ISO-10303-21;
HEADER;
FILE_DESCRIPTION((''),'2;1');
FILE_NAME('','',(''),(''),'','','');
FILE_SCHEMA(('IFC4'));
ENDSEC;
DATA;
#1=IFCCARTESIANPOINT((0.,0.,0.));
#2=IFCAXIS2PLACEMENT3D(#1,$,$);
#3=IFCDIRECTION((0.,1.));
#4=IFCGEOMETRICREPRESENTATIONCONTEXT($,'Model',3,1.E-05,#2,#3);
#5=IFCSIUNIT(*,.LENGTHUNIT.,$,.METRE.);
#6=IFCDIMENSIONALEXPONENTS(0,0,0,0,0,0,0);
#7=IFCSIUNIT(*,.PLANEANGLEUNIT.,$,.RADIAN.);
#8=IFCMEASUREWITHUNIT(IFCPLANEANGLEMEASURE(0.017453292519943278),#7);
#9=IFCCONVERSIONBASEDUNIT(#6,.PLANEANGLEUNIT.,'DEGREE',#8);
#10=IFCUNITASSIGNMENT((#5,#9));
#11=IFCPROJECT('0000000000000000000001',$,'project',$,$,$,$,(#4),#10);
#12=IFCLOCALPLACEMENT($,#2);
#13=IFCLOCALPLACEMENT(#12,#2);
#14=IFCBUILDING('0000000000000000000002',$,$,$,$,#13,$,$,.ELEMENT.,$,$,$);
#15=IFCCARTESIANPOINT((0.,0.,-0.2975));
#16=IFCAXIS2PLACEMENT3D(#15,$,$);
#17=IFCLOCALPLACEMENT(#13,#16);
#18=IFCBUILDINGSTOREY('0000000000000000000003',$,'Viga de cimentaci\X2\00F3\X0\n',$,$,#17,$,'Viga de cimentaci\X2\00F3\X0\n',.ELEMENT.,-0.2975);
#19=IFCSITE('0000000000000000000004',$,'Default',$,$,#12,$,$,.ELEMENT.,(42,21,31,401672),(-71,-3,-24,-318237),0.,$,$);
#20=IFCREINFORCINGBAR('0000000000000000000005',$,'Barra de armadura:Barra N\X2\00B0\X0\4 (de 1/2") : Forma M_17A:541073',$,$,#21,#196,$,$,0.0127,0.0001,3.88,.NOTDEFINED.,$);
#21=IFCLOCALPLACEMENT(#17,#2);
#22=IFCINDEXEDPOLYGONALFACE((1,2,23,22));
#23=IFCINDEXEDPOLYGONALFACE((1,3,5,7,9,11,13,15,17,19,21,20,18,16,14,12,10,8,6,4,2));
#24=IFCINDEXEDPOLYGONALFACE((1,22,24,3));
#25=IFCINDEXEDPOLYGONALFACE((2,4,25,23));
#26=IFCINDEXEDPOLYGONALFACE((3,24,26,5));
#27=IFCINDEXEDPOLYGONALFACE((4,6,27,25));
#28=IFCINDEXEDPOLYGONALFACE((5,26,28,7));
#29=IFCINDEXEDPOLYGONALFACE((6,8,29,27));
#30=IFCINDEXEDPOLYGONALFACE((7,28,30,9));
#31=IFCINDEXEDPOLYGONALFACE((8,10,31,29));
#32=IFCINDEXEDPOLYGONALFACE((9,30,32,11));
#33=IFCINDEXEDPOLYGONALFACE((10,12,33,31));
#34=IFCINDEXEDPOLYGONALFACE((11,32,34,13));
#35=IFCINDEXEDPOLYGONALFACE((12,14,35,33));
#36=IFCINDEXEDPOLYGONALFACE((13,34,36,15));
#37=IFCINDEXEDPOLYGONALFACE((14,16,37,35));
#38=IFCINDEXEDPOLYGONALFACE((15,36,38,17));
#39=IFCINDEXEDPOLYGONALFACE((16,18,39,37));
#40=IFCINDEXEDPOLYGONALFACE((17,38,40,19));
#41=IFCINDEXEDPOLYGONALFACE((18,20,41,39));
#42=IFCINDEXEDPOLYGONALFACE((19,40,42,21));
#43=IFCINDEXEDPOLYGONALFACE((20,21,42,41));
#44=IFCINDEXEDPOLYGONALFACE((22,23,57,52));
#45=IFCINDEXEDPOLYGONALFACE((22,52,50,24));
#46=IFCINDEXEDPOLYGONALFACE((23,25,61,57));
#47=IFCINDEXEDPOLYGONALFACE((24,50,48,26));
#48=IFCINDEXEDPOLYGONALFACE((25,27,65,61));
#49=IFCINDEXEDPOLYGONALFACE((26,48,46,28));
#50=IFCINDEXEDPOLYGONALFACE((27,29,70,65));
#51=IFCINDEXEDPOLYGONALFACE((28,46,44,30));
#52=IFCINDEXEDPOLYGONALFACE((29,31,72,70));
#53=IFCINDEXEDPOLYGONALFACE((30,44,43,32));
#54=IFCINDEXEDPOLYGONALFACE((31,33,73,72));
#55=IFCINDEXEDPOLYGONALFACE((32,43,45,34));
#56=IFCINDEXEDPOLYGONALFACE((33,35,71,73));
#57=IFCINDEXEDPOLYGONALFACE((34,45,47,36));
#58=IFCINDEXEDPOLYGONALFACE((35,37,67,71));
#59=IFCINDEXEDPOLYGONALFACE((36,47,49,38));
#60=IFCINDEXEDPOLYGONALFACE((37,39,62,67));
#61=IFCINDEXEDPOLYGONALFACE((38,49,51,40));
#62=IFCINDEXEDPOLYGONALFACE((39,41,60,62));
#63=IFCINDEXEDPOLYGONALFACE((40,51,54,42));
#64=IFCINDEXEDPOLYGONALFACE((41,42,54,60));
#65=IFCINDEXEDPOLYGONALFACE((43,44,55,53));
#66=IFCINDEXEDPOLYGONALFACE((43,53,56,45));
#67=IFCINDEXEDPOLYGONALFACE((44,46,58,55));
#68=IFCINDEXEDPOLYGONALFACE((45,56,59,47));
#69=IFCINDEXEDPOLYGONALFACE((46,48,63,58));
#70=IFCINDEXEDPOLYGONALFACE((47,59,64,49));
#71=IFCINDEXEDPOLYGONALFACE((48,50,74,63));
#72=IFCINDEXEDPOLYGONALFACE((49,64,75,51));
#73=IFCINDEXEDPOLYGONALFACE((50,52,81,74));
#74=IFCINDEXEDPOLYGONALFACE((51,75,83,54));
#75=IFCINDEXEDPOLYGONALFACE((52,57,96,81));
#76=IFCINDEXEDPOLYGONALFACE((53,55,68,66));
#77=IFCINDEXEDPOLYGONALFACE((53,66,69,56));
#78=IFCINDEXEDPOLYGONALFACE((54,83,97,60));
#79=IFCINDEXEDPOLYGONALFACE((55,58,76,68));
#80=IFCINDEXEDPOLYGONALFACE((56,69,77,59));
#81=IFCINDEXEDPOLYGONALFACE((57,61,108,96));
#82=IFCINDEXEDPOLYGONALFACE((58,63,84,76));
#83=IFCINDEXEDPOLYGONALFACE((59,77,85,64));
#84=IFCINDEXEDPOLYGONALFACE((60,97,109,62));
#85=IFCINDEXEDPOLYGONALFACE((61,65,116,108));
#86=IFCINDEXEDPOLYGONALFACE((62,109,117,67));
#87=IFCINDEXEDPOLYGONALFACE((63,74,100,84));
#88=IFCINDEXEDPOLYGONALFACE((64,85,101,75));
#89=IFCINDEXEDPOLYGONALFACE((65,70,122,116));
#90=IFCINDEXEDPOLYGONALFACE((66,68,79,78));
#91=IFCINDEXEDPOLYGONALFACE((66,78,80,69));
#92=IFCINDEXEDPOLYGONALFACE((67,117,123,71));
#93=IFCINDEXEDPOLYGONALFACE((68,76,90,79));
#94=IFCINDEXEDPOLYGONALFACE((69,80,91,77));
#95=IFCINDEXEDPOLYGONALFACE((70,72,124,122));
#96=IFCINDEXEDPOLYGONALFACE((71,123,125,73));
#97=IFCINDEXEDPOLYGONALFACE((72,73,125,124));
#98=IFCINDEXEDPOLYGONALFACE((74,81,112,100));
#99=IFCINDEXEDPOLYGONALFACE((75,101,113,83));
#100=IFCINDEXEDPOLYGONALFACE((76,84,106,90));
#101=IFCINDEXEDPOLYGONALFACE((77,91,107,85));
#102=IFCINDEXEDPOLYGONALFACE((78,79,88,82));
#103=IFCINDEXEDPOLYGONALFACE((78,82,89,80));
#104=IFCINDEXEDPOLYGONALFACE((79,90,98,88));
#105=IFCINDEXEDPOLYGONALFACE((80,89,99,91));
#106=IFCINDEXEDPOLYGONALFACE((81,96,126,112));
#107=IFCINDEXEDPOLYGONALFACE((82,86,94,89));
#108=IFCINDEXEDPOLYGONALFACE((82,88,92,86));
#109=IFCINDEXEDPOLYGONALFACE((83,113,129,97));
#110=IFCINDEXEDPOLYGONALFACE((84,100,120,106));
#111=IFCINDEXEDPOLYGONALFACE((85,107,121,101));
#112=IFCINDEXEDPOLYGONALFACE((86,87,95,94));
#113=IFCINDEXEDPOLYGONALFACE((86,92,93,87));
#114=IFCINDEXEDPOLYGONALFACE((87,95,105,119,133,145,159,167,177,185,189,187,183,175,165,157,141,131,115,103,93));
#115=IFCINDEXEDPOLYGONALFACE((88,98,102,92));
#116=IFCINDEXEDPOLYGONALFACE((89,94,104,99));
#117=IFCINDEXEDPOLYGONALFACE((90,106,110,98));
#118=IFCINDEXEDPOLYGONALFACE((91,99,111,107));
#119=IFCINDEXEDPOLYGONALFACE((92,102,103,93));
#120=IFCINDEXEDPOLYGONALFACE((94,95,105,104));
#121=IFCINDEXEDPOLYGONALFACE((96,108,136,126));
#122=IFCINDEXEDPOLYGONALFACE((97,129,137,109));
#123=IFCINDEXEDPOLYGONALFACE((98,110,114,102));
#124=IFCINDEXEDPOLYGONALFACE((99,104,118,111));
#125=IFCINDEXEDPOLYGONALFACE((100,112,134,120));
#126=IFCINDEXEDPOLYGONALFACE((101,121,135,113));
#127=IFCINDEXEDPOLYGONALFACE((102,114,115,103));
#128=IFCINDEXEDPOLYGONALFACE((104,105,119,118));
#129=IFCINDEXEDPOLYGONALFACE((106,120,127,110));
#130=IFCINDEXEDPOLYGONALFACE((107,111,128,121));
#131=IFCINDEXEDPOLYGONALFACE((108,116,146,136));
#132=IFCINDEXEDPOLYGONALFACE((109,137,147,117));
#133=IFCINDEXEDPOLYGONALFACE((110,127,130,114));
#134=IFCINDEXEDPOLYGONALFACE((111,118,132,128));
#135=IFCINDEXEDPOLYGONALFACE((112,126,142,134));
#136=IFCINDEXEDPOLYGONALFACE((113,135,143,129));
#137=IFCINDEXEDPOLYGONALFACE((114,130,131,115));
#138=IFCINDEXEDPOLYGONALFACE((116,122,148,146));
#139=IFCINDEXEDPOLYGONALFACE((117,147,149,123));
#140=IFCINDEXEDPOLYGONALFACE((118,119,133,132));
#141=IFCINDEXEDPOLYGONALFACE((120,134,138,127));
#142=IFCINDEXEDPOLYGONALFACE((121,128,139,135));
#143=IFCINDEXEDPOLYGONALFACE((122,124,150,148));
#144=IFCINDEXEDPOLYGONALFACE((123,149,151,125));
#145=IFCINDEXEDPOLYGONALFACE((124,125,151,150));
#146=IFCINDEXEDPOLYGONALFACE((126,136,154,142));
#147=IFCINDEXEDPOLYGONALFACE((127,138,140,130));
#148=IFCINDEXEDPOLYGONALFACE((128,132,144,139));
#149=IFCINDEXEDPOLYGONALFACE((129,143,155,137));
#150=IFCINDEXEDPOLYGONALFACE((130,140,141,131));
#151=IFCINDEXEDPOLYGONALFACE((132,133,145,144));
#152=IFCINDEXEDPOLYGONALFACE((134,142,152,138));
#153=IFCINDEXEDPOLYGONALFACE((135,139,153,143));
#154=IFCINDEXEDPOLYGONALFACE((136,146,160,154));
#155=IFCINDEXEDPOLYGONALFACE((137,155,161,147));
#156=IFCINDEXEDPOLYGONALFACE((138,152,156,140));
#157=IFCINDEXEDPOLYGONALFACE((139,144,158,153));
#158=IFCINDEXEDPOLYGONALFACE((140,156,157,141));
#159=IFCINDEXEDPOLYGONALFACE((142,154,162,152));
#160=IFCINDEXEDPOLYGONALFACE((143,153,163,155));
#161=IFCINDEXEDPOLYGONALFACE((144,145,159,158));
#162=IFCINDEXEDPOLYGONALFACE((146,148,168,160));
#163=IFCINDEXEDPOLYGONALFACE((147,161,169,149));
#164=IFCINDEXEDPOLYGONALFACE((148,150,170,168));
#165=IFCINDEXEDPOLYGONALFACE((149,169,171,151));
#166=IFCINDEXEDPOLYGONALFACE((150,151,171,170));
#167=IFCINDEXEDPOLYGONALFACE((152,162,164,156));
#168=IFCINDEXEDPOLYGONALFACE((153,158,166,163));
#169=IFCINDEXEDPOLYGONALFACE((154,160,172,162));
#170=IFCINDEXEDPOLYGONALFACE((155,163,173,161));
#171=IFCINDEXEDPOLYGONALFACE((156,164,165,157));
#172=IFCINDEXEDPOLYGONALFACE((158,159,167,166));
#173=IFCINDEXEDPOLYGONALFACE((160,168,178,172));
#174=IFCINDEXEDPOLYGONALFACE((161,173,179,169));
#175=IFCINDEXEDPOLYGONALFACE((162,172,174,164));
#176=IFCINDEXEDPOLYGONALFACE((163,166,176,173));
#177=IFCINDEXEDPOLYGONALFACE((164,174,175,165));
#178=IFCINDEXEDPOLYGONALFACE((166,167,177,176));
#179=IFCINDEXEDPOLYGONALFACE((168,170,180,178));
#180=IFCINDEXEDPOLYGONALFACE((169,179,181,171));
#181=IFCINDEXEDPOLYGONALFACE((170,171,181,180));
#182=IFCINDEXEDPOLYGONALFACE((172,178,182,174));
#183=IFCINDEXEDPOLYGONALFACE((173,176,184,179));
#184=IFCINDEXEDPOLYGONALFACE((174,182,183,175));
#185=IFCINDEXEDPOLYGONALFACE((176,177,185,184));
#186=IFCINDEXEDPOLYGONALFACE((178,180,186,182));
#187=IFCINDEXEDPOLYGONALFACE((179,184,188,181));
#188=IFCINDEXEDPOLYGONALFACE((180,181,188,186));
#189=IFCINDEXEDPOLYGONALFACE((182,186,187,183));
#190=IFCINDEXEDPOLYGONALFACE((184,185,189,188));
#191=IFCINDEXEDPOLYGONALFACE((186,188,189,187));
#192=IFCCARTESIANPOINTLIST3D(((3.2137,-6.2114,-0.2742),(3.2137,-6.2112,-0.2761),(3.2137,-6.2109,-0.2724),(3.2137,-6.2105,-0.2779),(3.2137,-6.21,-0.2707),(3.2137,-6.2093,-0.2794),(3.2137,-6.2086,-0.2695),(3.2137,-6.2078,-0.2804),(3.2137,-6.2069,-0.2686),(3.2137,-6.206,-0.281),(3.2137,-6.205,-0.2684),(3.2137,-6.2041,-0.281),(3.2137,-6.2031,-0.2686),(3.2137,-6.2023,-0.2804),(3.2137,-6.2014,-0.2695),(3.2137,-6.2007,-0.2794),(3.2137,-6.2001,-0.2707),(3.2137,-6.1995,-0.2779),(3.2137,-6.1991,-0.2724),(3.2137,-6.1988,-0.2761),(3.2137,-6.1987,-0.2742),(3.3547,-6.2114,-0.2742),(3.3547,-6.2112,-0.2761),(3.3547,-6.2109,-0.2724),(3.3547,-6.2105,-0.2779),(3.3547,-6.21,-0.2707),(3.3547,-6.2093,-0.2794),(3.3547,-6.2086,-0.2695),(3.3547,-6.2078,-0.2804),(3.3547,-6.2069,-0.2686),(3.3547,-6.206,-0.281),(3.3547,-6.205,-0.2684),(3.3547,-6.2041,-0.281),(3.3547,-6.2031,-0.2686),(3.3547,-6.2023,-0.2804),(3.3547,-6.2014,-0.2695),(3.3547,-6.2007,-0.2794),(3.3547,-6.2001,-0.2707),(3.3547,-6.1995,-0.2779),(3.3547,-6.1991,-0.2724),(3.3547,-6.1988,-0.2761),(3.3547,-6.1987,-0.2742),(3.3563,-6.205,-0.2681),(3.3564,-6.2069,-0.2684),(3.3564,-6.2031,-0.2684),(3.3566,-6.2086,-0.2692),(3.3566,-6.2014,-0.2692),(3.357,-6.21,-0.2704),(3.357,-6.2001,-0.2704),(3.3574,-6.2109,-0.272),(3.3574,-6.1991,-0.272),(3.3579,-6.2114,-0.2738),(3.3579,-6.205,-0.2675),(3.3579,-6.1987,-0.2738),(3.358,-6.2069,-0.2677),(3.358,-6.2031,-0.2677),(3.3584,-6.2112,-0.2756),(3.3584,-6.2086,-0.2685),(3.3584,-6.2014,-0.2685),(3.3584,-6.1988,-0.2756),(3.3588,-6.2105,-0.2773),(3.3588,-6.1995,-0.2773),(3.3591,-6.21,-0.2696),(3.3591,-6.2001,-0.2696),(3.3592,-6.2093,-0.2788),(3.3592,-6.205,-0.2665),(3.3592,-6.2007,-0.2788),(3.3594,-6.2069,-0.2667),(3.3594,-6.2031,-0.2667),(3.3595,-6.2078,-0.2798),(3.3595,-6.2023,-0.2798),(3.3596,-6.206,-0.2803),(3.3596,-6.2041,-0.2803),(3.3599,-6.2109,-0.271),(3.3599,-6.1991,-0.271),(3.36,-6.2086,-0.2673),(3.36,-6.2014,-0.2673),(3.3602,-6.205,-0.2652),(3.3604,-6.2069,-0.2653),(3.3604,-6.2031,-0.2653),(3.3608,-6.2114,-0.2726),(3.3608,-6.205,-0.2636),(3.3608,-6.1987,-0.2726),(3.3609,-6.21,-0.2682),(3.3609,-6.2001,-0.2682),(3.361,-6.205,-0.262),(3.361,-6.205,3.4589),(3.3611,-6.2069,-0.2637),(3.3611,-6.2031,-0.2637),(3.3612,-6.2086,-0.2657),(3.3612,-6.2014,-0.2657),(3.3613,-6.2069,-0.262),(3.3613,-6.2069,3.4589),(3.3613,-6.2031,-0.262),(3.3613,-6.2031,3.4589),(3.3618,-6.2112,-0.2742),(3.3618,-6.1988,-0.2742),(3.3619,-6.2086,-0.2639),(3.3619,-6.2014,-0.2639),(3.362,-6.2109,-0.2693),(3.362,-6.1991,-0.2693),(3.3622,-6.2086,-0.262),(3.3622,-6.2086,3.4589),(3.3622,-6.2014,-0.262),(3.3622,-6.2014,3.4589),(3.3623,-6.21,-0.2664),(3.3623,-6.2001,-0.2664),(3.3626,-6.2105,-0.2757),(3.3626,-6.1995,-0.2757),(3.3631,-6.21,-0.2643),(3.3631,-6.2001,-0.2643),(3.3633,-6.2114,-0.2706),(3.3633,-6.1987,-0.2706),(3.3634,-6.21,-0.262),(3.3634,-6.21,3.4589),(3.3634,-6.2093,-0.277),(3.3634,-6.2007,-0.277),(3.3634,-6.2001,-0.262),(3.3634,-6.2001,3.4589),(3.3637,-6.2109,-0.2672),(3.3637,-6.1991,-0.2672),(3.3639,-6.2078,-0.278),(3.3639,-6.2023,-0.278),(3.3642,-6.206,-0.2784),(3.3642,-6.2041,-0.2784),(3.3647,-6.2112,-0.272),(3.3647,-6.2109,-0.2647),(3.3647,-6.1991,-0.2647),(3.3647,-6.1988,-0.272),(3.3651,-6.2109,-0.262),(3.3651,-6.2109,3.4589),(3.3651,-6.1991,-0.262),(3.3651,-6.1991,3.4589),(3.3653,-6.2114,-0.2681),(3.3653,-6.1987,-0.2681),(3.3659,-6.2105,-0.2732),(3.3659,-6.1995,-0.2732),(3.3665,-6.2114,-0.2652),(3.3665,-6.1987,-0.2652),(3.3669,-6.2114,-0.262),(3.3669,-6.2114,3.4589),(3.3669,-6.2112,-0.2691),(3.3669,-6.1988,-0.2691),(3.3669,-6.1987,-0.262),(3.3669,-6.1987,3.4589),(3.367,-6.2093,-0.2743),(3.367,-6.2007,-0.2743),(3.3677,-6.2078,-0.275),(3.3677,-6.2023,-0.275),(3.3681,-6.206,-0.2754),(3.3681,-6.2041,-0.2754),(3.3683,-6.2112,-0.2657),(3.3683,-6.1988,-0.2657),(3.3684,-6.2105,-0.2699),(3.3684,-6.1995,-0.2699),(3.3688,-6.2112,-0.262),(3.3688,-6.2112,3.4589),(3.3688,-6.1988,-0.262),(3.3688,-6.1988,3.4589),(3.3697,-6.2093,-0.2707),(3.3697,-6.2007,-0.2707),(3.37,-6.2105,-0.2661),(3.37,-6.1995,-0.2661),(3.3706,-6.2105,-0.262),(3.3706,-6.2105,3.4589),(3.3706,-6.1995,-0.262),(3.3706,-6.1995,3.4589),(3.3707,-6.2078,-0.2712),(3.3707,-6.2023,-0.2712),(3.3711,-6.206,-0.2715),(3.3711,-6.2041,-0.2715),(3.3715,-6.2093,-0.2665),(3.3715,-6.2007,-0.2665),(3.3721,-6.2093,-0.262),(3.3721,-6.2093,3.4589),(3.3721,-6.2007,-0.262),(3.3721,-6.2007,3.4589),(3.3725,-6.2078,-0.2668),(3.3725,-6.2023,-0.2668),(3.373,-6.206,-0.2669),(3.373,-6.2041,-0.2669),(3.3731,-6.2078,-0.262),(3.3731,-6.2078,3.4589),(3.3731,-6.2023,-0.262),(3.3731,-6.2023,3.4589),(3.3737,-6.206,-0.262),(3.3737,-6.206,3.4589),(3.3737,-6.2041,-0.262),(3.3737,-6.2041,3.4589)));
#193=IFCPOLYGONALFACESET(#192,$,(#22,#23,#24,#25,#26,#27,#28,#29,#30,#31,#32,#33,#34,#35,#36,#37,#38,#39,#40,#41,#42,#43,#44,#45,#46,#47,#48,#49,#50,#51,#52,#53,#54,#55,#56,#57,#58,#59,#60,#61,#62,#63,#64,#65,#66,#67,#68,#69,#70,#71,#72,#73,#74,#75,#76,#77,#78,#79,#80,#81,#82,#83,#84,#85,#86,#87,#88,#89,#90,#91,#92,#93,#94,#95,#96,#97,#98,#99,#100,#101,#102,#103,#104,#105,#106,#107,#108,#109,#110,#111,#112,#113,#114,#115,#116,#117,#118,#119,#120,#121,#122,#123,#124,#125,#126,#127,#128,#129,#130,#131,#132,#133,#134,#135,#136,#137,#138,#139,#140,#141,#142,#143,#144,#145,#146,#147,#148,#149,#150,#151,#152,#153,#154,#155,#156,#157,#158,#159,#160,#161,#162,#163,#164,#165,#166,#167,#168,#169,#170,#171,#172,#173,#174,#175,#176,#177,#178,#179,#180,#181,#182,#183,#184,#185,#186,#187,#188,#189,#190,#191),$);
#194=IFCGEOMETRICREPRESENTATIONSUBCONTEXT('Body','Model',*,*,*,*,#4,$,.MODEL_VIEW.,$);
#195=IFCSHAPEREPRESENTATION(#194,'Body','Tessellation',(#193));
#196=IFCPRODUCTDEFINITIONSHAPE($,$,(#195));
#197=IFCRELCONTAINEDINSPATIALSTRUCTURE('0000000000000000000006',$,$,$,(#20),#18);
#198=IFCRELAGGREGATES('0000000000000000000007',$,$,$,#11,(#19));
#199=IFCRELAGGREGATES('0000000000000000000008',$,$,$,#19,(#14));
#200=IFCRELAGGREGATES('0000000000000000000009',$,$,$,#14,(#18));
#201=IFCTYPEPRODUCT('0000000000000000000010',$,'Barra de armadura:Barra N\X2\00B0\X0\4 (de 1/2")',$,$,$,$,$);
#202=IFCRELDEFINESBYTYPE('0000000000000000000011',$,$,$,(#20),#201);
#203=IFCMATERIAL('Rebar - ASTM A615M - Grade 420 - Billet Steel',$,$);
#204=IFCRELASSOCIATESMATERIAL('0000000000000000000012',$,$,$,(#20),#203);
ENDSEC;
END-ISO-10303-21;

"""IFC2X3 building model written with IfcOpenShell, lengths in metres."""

from ifc_helpers import new_model, entity, si_unit, converted_unit, direction, frame, origin, place, context, subcontext, project, spatial, material, type_object, element, save


model = new_model("IFC2X3")

# Units and contexts
model_context = context("Model", 3, precision=1e-05, world=origin(), true_north=direction((0.0, 1.0)))
body_context = subcontext(model_context, "Body", "Model", "MODEL_VIEW")
ifc_project = project(units=[si_unit("LENGTHUNIT", "METRE"), converted_unit("PLANEANGLEUNIT", "DEGREE", entity("IfcPlaneAngleMeasure", 0.017453292519943278), si_unit("PLANEANGLEUNIT", "RADIAN"), dimensions=[0, 0, 0, 0, 0, 0, 0])], contexts=[model_context])

# Site, building, storey
site_placement = place(None, origin())
site = spatial("IfcSite", under=ifc_project, at=site_placement, Name="Default", CompositionType="ELEMENT", RefLatitude=(42, 21, 31, 401672), RefLongitude=(-71, -3, -24, -318237), RefElevation=0.0)
building_placement = place(site_placement, origin())
building = spatial("IfcBuilding", under=site, at=building_placement, CompositionType="ELEMENT")
storey_placement = place(building_placement, frame((0.0, 0.0, -0.2975)))
storey = spatial("IfcBuildingStorey", under=building, at=storey_placement, Name="Viga de cimentación", LongName="Viga de cimentación", CompositionType="ELEMENT", Elevation=-0.2975)

# Reinforcing bar
ifc_material_1 = material(Name="Rebar - ASTM A615M - Grade 420 - Billet Steel")
type_product_1 = type_object("IfcTypeProduct", Name="Barra de armadura:Barra N°4 (de 1/2\")")
reinforcing_bar_1_placement = place(storey_placement, origin())
element("IfcReinforcingBar", 1, at=reinforcing_bar_1_placement, inside=storey, type_object=type_product_1, material=ifc_material_1, Name="Barra de armadura:Barra N°4 (de 1/2\") : Forma M_17A:541073", BarLength=3.88, BarRole="NOTDEFINED", CrossSectionArea=0.0001, NominalDiameter=0.0127, context=body_context, shape_type="AdvancedSweptSolid", body=[
    entity("IfcSweptDiskSolid", entity("IfcCompositeCurve", [entity("IfcCompositeCurveSegment", "CONTINUOUS", True, entity("IfcPolyline", [entity("IfcCartesianPoint", [3.3674, -6.205, 3.4589]), entity("IfcCartesianPoint", [3.3674, -6.205, -0.262])])), entity("IfcCompositeCurveSegment", "CONTINUOUS", True, entity("IfcTrimmedCurve", entity("IfcCircle", entity("IfcAxis2Placement3D", entity("IfcCartesianPoint", [3.3547, -6.205, -0.262]), entity("IfcDirection", [0.0, 1.0, 0.0]), entity("IfcDirection", [0.0, 0.0, -1.0])), 0.0127), [entity("IfcParameterValue", 270.0)], [entity("IfcParameterValue", 360.0)], True, "PARAMETER")), entity("IfcCompositeCurveSegment", "CONTINUOUS", True, entity("IfcPolyline", [entity("IfcCartesianPoint", [3.3547, -6.205, -0.2747]), entity("IfcCartesianPoint", [3.2137, -6.205, -0.2747])]))], False), 0.0063, None, 0.0, 92.0),
])

save(model, "model.ifc")
